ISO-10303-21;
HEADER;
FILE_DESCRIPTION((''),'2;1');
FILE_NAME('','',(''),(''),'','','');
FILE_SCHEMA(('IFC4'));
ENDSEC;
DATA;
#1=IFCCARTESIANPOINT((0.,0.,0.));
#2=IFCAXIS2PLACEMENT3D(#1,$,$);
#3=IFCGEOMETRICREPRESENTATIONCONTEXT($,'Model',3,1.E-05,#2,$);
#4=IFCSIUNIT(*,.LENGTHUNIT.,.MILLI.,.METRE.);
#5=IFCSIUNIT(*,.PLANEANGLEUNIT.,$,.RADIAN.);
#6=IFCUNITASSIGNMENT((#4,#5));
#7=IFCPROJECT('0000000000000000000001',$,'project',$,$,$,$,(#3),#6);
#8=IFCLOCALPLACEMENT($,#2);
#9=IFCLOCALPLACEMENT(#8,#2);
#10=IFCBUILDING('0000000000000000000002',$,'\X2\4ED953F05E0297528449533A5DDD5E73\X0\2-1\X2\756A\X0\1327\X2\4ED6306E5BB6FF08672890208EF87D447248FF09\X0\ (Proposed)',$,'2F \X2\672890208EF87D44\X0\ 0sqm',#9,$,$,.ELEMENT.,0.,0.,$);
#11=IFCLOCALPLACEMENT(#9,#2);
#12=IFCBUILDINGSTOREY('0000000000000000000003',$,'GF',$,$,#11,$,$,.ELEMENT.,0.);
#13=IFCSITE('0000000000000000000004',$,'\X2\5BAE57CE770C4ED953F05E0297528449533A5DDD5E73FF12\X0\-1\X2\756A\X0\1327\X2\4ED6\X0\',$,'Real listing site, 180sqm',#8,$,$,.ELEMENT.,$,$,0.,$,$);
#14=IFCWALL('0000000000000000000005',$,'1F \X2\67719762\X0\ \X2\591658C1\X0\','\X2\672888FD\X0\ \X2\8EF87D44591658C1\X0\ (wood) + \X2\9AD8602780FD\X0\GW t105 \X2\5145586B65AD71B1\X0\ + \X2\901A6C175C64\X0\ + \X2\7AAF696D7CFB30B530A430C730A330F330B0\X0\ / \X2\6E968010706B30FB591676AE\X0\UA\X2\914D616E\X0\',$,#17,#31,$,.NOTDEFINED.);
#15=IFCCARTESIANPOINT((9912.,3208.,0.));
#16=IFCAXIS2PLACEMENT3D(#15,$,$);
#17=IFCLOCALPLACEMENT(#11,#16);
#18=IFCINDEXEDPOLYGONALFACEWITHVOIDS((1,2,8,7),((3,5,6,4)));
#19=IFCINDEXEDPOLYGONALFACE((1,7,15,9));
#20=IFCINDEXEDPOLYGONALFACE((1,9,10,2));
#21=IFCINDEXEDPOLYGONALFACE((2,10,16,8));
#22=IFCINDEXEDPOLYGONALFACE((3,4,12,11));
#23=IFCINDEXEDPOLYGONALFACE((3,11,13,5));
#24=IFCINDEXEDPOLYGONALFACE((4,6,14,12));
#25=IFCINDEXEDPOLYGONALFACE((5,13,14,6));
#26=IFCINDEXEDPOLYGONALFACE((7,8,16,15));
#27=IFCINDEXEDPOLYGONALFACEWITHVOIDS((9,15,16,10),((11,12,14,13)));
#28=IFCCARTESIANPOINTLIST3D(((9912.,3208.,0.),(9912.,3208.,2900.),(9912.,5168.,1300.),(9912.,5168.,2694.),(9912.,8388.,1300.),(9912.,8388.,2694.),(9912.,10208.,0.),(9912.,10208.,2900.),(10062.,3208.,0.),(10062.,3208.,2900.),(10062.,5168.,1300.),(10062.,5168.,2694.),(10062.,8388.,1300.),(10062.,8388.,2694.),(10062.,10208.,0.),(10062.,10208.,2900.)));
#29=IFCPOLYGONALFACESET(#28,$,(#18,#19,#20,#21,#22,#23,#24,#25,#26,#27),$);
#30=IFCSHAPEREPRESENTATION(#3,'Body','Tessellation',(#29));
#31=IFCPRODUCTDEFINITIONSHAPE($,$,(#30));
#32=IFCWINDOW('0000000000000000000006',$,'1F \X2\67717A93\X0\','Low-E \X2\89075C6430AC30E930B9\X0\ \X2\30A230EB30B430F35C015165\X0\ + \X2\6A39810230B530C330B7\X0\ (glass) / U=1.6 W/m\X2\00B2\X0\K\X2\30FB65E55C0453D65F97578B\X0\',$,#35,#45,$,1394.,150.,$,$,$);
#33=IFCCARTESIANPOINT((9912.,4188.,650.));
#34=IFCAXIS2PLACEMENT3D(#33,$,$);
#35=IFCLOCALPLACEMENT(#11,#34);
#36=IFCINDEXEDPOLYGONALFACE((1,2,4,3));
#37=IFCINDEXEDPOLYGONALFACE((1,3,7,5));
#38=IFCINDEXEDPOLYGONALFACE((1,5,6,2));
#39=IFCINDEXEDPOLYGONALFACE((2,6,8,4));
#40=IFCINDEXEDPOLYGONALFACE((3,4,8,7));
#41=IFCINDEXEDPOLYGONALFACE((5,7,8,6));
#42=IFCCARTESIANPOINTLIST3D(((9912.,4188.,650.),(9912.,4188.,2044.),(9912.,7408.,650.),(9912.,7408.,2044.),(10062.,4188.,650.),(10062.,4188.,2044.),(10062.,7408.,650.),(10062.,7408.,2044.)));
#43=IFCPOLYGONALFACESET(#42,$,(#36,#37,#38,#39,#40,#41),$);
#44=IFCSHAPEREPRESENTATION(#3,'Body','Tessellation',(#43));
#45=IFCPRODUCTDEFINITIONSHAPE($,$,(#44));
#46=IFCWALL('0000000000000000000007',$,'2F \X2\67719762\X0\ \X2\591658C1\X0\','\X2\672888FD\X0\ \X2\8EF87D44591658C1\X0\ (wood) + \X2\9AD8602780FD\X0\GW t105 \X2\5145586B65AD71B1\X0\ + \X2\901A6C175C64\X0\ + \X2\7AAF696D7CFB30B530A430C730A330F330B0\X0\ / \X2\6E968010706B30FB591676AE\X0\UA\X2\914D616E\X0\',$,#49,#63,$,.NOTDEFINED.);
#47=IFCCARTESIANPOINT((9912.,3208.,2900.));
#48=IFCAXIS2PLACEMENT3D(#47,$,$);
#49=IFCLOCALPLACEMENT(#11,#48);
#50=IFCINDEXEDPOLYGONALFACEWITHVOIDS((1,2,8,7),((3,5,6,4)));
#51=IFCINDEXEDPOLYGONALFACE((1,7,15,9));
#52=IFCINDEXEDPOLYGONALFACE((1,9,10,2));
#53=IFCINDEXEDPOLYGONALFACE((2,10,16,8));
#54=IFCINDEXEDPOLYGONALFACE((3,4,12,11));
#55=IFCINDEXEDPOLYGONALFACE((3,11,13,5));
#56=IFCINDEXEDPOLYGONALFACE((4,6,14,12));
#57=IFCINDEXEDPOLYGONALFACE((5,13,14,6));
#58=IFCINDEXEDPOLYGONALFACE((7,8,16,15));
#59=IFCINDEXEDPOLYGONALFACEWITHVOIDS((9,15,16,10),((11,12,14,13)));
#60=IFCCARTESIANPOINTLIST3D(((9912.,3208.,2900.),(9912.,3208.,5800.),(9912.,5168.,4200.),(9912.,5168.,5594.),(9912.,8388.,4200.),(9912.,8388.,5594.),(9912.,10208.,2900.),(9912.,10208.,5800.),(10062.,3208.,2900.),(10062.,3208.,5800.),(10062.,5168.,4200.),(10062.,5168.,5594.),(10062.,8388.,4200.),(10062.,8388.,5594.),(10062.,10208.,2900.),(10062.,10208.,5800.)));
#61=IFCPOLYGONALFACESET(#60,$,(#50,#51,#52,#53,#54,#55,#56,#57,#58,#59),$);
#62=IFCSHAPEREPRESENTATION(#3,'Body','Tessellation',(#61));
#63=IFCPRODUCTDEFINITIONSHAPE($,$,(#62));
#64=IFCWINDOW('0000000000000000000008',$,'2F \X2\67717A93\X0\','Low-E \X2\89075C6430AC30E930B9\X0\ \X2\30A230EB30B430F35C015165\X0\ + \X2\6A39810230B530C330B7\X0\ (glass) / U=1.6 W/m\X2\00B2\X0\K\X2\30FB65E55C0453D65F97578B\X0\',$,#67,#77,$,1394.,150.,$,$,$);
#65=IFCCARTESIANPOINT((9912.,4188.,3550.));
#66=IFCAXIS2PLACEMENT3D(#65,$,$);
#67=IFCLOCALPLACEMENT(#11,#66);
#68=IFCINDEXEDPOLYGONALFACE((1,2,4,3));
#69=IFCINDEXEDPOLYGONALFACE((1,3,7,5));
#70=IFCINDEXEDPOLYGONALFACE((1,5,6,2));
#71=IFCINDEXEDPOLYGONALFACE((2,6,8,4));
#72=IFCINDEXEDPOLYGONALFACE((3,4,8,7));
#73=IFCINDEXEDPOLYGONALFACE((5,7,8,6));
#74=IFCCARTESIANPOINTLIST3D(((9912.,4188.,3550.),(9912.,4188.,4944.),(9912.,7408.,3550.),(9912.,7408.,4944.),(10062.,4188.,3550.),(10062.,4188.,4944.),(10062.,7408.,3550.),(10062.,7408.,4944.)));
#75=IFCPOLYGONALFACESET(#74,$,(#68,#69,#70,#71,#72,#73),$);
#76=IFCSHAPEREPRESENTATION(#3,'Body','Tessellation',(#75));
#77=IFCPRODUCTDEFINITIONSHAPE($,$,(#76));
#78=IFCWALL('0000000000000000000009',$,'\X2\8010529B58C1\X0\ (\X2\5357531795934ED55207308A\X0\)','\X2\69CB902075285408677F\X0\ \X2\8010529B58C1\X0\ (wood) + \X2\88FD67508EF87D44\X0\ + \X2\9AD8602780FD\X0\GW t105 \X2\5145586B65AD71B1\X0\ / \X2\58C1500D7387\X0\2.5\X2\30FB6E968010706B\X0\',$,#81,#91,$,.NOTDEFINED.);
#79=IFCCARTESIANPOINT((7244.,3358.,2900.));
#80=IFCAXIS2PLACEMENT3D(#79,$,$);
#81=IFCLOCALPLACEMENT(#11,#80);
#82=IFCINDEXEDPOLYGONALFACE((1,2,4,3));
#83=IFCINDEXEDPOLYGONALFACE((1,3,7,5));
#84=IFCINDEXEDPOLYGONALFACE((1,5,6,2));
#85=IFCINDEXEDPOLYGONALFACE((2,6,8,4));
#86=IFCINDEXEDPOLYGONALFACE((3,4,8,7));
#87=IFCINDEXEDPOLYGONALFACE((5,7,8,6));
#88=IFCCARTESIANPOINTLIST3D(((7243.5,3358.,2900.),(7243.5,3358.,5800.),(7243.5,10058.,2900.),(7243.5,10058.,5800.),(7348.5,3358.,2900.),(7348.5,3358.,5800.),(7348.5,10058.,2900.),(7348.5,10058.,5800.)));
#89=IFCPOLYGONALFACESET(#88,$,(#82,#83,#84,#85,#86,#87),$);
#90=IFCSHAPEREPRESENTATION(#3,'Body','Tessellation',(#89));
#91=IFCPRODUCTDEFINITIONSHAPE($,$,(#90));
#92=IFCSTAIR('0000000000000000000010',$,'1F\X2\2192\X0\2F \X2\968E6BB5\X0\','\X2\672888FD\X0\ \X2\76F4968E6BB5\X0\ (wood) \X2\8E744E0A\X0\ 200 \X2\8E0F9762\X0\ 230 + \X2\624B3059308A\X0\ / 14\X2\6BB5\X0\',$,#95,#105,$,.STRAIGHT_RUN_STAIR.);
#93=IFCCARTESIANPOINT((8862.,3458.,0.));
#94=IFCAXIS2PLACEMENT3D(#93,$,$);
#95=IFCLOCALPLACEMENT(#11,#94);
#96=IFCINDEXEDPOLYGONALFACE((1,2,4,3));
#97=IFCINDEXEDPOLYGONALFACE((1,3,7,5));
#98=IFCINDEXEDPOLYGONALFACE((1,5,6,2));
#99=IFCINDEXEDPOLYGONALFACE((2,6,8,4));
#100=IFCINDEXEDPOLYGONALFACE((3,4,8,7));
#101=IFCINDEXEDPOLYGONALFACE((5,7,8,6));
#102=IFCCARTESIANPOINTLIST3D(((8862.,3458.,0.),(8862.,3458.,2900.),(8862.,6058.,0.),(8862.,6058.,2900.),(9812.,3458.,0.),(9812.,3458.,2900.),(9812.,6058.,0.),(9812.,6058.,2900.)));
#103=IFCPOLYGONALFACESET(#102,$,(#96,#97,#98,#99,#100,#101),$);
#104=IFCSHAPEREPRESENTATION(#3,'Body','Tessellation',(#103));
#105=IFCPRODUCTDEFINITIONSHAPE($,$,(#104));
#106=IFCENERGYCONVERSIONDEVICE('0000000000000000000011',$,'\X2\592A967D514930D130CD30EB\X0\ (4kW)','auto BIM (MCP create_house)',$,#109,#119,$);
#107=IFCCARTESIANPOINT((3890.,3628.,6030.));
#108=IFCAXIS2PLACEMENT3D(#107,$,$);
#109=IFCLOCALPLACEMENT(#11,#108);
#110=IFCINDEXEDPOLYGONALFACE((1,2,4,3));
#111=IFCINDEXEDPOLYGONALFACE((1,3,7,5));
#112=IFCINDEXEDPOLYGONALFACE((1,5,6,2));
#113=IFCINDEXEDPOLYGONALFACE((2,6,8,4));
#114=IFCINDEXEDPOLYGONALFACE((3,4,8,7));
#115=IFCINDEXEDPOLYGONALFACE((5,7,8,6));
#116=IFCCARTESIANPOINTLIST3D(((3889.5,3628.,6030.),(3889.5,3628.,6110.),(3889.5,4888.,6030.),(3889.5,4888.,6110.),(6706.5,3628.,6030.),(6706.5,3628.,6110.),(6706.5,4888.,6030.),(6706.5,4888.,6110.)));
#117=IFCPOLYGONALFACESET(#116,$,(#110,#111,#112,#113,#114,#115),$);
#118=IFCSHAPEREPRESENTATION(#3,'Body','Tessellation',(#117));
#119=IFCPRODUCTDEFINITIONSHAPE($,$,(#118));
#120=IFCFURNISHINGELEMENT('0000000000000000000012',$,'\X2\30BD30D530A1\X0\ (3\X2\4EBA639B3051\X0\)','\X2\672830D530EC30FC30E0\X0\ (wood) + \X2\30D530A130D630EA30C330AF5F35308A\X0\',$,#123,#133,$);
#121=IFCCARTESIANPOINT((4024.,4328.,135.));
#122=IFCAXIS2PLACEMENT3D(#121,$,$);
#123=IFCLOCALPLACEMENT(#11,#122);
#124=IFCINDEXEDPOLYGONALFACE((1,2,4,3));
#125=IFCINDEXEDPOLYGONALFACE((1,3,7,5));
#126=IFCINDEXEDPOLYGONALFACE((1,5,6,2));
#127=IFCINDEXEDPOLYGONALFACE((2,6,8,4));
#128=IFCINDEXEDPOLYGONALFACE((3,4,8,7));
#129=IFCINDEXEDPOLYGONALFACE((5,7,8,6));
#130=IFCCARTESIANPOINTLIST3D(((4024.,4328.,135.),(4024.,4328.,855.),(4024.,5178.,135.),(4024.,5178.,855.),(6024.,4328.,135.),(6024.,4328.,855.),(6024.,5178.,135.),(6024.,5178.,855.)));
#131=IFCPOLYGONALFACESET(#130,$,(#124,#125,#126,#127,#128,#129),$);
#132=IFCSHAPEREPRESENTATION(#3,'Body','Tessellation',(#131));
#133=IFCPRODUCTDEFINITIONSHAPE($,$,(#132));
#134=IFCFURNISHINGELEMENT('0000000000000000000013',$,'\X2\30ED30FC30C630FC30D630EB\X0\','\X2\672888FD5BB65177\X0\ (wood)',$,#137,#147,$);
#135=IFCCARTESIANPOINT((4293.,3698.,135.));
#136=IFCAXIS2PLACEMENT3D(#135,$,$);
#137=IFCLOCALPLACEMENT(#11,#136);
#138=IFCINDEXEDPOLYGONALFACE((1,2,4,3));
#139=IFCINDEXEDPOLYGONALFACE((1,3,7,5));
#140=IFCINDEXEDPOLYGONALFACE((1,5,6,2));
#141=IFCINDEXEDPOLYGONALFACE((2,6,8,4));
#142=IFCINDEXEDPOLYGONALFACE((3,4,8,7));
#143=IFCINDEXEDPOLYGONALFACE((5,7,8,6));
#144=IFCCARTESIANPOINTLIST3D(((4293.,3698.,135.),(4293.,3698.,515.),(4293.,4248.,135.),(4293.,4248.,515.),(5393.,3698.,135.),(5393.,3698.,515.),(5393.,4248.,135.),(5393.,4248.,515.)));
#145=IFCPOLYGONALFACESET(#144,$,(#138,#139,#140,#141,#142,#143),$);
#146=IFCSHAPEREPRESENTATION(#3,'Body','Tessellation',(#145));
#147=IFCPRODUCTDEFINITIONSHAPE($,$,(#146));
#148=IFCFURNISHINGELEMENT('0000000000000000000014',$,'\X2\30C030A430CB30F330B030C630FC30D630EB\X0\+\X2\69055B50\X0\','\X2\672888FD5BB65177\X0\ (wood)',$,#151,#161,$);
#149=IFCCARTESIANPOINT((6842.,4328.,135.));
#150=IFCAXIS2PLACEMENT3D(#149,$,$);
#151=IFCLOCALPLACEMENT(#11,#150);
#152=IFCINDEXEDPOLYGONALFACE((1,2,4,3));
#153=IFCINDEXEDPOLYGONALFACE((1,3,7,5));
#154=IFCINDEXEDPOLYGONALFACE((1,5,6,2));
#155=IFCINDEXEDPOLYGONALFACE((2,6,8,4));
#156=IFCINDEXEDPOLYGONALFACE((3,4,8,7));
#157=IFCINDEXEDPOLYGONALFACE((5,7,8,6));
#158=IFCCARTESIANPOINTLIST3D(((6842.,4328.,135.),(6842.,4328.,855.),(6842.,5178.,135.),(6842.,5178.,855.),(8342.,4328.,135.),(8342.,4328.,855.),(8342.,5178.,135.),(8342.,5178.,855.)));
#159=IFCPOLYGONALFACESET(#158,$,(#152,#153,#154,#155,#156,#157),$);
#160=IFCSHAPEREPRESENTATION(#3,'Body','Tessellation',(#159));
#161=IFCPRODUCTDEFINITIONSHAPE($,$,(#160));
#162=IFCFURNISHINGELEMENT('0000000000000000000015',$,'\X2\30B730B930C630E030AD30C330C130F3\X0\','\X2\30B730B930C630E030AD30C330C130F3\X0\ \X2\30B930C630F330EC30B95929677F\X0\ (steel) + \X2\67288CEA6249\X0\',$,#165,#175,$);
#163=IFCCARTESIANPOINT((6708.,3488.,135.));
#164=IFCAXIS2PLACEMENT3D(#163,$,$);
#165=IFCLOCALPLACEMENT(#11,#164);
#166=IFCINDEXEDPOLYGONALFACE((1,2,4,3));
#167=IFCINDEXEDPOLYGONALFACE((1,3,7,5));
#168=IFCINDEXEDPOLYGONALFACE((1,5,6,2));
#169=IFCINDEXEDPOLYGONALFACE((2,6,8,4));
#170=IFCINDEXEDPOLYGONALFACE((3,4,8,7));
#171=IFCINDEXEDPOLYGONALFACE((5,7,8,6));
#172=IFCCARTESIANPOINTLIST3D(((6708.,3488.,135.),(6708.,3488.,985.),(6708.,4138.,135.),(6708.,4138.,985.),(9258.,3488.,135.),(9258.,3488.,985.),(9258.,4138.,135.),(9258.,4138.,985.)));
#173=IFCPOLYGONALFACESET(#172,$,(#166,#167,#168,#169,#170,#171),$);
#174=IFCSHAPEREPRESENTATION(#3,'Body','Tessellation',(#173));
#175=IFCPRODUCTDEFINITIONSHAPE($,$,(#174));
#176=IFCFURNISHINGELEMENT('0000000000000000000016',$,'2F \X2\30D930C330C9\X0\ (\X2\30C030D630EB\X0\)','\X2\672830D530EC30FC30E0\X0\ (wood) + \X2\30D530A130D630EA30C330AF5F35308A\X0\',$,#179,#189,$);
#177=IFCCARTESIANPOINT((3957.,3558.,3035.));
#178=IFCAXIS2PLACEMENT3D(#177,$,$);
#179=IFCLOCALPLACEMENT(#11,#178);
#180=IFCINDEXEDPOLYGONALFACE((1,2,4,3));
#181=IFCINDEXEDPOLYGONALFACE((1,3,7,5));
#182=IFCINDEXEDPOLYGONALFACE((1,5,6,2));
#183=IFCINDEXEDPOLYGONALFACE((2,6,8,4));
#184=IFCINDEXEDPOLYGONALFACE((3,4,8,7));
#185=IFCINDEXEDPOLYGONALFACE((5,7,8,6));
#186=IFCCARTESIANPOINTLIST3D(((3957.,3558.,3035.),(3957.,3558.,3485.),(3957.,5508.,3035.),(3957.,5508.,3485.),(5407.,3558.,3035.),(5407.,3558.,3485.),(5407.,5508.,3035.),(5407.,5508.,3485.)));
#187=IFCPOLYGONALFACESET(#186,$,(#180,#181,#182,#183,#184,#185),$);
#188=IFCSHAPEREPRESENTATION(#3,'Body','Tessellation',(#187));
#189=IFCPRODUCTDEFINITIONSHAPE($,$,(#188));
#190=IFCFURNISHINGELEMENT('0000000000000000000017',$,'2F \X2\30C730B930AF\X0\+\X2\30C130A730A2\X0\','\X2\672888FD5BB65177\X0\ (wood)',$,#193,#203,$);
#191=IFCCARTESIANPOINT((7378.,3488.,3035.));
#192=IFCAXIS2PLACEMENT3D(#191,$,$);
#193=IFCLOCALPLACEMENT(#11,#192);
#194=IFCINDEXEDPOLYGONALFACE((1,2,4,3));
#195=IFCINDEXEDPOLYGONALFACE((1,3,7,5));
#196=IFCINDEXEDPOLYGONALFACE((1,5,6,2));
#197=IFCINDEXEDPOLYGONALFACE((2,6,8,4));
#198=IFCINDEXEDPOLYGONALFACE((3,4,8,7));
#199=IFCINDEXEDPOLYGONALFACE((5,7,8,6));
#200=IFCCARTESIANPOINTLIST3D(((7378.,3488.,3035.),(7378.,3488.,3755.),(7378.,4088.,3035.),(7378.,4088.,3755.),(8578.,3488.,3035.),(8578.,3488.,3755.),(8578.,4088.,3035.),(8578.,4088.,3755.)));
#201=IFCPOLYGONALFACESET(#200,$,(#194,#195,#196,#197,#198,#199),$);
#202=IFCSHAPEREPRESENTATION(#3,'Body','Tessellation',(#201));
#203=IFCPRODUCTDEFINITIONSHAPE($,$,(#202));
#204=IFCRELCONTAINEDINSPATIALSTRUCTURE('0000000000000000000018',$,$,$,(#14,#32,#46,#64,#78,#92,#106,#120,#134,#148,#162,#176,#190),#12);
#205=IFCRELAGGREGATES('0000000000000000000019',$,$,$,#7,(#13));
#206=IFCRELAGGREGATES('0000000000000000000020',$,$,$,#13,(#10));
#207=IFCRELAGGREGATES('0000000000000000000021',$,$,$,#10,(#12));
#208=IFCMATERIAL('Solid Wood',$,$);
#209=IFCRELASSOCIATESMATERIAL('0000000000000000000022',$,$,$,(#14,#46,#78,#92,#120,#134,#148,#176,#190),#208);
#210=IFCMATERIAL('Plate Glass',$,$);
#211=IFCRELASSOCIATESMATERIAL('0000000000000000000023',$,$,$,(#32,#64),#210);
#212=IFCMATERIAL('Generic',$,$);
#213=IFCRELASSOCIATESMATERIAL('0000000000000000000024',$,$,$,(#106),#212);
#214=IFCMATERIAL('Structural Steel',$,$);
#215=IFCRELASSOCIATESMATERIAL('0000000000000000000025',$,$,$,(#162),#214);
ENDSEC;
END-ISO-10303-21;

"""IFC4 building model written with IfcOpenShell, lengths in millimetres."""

from ifc_helpers import new_model, si_unit, frame, frame_2d, origin, place, context, project, spatial, rectangle, extrude, material, element, fill, save


model = new_model("IFC4")

# Units and contexts
model_context = context("Model", 3, precision=1e-05, world=origin())
ifc_project = project(units=[si_unit("LENGTHUNIT", "METRE", prefix="MILLI"), si_unit("PLANEANGLEUNIT", "RADIAN")], contexts=[model_context])

# Site, building, storey
site_placement = place(None, origin())
site = spatial("IfcSite", under=ifc_project, at=site_placement, Name="宮城県仙台市青葉区川平２-1番1327他", ObjectType="Real listing site, 180sqm", CompositionType="ELEMENT", RefElevation=0.0)
building_placement = place(site_placement, origin())
building = spatial("IfcBuilding", under=site, at=building_placement, Name="仙台市青葉区川平2-1番1327他の家（木造軸組版） (Proposed)", ObjectType="2F 木造軸組 0sqm", CompositionType="ELEMENT", ElevationOfRefHeight=0.0, ElevationOfTerrain=0.0)
storey_placement = place(building_placement, origin())
storey = spatial("IfcBuildingStorey", under=building, at=storey_placement, Name="GF", CompositionType="ELEMENT", Elevation=0.0)

# Wall, opening, window
ifc_material_1 = material(Name="Solid Wood")
wall_1_placement = place(storey_placement, frame((9912.0, 3208.0, 0.0)))
wall_1 = element("IfcWall", 1, at=wall_1_placement, inside=storey, material=ifc_material_1, Name="1F 東面 外壁", Description="木製 軸組外壁 (wood) + 高性能GW t105 充填断熱 + 通気層 + 窯業系サイディング / 準耐火・外皮UA配慮", PredefinedType="NOTDEFINED", context=model_context, shape_type="SweptSolid", body=[
    extrude(rectangle(XDim=150.0, YDim=7000.0, at=frame_2d((75.0, 3500.0))), frame((9912.0, 3208.0, 0.0)), (0.0, 0.0, 1.0), 2900.0),
])
opening_1_placement = place(storey_placement, frame((9912.0, 4188.0, 650.0)))
opening_1 = element("IfcOpeningElement", 2, at=opening_1_placement, cuts=wall_1, PredefinedType="NOTDEFINED", context=model_context, shape_type="SweptSolid", body=[
    extrude(rectangle(XDim=150.0, YDim=3220.0, at=frame_2d((75.0, 1610.0))), frame((9912.0, 4188.0, 650.0)), (0.0, 0.0, 1.0), 1394.0),
])
ifc_material_2 = material(Name="Plate Glass")
window_1_placement = place(storey_placement, frame((9912.0, 4188.0, 650.0)))
window_1 = element("IfcWindow", 3, at=window_1_placement, inside=storey, material=ifc_material_2, Name="1F 東窓", Description="Low-E 複層ガラス アルゴン封入 + 樹脂サッシ (glass) / U=1.6 W/m²K・日射取得型", OverallHeight=1394.0, OverallWidth=150.0, context=model_context, shape_type="SweptSolid", body=[
    extrude(rectangle(XDim=150.0, YDim=3220.0, at=frame_2d((75.0, 1610.0))), frame((9912.0, 4188.0, 650.0)), (0.0, 0.0, 1.0), 1394.0),
])
fill(opening_1, window_1)

# Wall, opening, window
wall_2_placement = place(storey_placement, frame((9912.0, 3208.0, 2900.0)))
wall_2 = element("IfcWall", 4, at=wall_2_placement, inside=storey, material=ifc_material_1, Name="2F 東面 外壁", Description="木製 軸組外壁 (wood) + 高性能GW t105 充填断熱 + 通気層 + 窯業系サイディング / 準耐火・外皮UA配慮", PredefinedType="NOTDEFINED", context=model_context, shape_type="SweptSolid", body=[
    extrude(rectangle(XDim=150.0, YDim=7000.0, at=frame_2d((75.0, 3500.0))), frame((9912.0, 3208.0, 2900.0)), (0.0, 0.0, 1.0), 2900.0),
])
opening_2_placement = place(storey_placement, frame((9912.0, 4188.0, 3550.0)))
opening_2 = element("IfcOpeningElement", 5, at=opening_2_placement, cuts=wall_2, PredefinedType="NOTDEFINED", context=model_context, shape_type="SweptSolid", body=[
    extrude(rectangle(XDim=150.0, YDim=3220.0, at=frame_2d((75.0, 1610.0))), frame((9912.0, 4188.0, 3550.0)), (0.0, 0.0, 1.0), 1394.0),
])
window_2_placement = place(storey_placement, frame((9912.0, 4188.0, 3550.0)))
window_2 = element("IfcWindow", 6, at=window_2_placement, inside=storey, material=ifc_material_2, Name="2F 東窓", Description="Low-E 複層ガラス アルゴン封入 + 樹脂サッシ (glass) / U=1.6 W/m²K・日射取得型", OverallHeight=1394.0, OverallWidth=150.0, context=model_context, shape_type="SweptSolid", body=[
    extrude(rectangle(XDim=150.0, YDim=3220.0, at=frame_2d((75.0, 1610.0))), frame((9912.0, 4188.0, 3550.0)), (0.0, 0.0, 1.0), 1394.0),
])
fill(opening_2, window_2)

# Wall
wall_3_placement = place(storey_placement, frame((7244.0, 3358.0, 2900.0)))
element("IfcWall", 7, at=wall_3_placement, inside=storey, material=ifc_material_1, Name="耐力壁 (南北間仕切り)", Description="構造用合板 耐力壁 (wood) + 製材軸組 + 高性能GW t105 充填断熱 / 壁倍率2.5・準耐火", PredefinedType="NOTDEFINED", context=model_context, shape_type="SweptSolid", body=[
    extrude(rectangle(XDim=105.0, YDim=6700.0, at=frame_2d((52.0, 3350.0))), frame((7244.0, 3358.0, 2900.0)), (0.0, 0.0, 1.0), 2900.0),
])

# Stair
stair_placement = place(storey_placement, frame((8862.0, 3458.0, 0.0)))
element("IfcStair", 8, at=stair_placement, inside=storey, material=ifc_material_1, Name="1F→2F 階段", Description="木製 直階段 (wood) 蹴上 200 踏面 230 + 手すり / 14段", PredefinedType="STRAIGHT_RUN_STAIR", context=model_context, shape_type="SweptSolid", body=[
    extrude(rectangle(XDim=950.0, YDim=2600.0, at=frame_2d((475.0, 1300.0))), frame((8862.0, 3458.0, 0.0)), (0.0, 0.0, 1.0), 2900.0),
])

# Energy conversion device
ifc_material_3 = material(Name="Generic")
energy_conversion_device_placement = place(storey_placement, frame((3890.0, 3628.0, 6030.0)))
element("IfcEnergyConversionDevice", 9, at=energy_conversion_device_placement, inside=storey, material=ifc_material_3, Name="太陽光パネル (4kW)", Description="auto BIM (MCP create_house)", context=model_context, shape_type="SweptSolid", body=[
    extrude(rectangle(XDim=2817.0, YDim=1260.0, at=frame_2d((1408.0, 630.0))), frame((3890.0, 3628.0, 6030.0)), (0.0, 0.0, 1.0), 80.0),
])

# Furnishing elements
furnishing_1_placement = place(storey_placement, frame((4024.0, 4328.0, 135.0)))
element("IfcFurnishingElement", 10, at=furnishing_1_placement, inside=storey, material=ifc_material_1, Name="ソファ (3人掛け)", Description="木フレーム (wood) + ファブリック張り", context=model_context, shape_type="SweptSolid", body=[
    extrude(rectangle(XDim=2000.0, YDim=850.0, at=frame_2d((1000.0, 425.0))), frame((4024.0, 4328.0, 135.0)), (0.0, 0.0, 1.0), 720.0),
])
furnishing_2_placement = place(storey_placement, frame((4293.0, 3698.0, 135.0)))
element("IfcFurnishingElement", 11, at=furnishing_2_placement, inside=storey, material=ifc_material_1, Name="ローテーブル", Description="木製家具 (wood)", context=model_context, shape_type="SweptSolid", body=[
    extrude(rectangle(XDim=1100.0, YDim=550.0, at=frame_2d((550.0, 275.0))), frame((4293.0, 3698.0, 135.0)), (0.0, 0.0, 1.0), 380.0),
])
furnishing_3_placement = place(storey_placement, frame((6842.0, 4328.0, 135.0)))
element("IfcFurnishingElement", 12, at=furnishing_3_placement, inside=storey, material=ifc_material_1, Name="ダイニングテーブル+椅子", Description="木製家具 (wood)", context=model_context, shape_type="SweptSolid", body=[
    extrude(rectangle(XDim=1500.0, YDim=850.0, at=frame_2d((750.0, 425.0))), frame((6842.0, 4328.0, 135.0)), (0.0, 0.0, 1.0), 720.0),
])
ifc_material_4 = material(Name="Structural Steel")
furnishing_4_placement = place(storey_placement, frame((6708.0, 3488.0, 135.0)))
element("IfcFurnishingElement", 13, at=furnishing_4_placement, inside=storey, material=ifc_material_4, Name="システムキッチン", Description="システムキッチン ステンレス天板 (steel) + 木質扉", context=model_context, shape_type="SweptSolid", body=[
    extrude(rectangle(XDim=2550.0, YDim=650.0, at=frame_2d((1275.0, 325.0))), frame((6708.0, 3488.0, 135.0)), (0.0, 0.0, 1.0), 850.0),
])
furnishing_5_placement = place(storey_placement, frame((3957.0, 3558.0, 3035.0)))
element("IfcFurnishingElement", 14, at=furnishing_5_placement, inside=storey, material=ifc_material_1, Name="2F ベッド (ダブル)", Description="木フレーム (wood) + ファブリック張り", context=model_context, shape_type="SweptSolid", body=[
    extrude(rectangle(XDim=1450.0, YDim=1950.0, at=frame_2d((725.0, 975.0))), frame((3957.0, 3558.0, 3035.0)), (0.0, 0.0, 1.0), 450.0),
])
furnishing_6_placement = place(storey_placement, frame((7378.0, 3488.0, 3035.0)))
element("IfcFurnishingElement", 15, at=furnishing_6_placement, inside=storey, material=ifc_material_1, Name="2F デスク+チェア", Description="木製家具 (wood)", context=model_context, shape_type="SweptSolid", body=[
    extrude(rectangle(XDim=1200.0, YDim=600.0, at=frame_2d((600.0, 300.0))), frame((7378.0, 3488.0, 3035.0)), (0.0, 0.0, 1.0), 720.0),
])

save(model, "model.ifc")
